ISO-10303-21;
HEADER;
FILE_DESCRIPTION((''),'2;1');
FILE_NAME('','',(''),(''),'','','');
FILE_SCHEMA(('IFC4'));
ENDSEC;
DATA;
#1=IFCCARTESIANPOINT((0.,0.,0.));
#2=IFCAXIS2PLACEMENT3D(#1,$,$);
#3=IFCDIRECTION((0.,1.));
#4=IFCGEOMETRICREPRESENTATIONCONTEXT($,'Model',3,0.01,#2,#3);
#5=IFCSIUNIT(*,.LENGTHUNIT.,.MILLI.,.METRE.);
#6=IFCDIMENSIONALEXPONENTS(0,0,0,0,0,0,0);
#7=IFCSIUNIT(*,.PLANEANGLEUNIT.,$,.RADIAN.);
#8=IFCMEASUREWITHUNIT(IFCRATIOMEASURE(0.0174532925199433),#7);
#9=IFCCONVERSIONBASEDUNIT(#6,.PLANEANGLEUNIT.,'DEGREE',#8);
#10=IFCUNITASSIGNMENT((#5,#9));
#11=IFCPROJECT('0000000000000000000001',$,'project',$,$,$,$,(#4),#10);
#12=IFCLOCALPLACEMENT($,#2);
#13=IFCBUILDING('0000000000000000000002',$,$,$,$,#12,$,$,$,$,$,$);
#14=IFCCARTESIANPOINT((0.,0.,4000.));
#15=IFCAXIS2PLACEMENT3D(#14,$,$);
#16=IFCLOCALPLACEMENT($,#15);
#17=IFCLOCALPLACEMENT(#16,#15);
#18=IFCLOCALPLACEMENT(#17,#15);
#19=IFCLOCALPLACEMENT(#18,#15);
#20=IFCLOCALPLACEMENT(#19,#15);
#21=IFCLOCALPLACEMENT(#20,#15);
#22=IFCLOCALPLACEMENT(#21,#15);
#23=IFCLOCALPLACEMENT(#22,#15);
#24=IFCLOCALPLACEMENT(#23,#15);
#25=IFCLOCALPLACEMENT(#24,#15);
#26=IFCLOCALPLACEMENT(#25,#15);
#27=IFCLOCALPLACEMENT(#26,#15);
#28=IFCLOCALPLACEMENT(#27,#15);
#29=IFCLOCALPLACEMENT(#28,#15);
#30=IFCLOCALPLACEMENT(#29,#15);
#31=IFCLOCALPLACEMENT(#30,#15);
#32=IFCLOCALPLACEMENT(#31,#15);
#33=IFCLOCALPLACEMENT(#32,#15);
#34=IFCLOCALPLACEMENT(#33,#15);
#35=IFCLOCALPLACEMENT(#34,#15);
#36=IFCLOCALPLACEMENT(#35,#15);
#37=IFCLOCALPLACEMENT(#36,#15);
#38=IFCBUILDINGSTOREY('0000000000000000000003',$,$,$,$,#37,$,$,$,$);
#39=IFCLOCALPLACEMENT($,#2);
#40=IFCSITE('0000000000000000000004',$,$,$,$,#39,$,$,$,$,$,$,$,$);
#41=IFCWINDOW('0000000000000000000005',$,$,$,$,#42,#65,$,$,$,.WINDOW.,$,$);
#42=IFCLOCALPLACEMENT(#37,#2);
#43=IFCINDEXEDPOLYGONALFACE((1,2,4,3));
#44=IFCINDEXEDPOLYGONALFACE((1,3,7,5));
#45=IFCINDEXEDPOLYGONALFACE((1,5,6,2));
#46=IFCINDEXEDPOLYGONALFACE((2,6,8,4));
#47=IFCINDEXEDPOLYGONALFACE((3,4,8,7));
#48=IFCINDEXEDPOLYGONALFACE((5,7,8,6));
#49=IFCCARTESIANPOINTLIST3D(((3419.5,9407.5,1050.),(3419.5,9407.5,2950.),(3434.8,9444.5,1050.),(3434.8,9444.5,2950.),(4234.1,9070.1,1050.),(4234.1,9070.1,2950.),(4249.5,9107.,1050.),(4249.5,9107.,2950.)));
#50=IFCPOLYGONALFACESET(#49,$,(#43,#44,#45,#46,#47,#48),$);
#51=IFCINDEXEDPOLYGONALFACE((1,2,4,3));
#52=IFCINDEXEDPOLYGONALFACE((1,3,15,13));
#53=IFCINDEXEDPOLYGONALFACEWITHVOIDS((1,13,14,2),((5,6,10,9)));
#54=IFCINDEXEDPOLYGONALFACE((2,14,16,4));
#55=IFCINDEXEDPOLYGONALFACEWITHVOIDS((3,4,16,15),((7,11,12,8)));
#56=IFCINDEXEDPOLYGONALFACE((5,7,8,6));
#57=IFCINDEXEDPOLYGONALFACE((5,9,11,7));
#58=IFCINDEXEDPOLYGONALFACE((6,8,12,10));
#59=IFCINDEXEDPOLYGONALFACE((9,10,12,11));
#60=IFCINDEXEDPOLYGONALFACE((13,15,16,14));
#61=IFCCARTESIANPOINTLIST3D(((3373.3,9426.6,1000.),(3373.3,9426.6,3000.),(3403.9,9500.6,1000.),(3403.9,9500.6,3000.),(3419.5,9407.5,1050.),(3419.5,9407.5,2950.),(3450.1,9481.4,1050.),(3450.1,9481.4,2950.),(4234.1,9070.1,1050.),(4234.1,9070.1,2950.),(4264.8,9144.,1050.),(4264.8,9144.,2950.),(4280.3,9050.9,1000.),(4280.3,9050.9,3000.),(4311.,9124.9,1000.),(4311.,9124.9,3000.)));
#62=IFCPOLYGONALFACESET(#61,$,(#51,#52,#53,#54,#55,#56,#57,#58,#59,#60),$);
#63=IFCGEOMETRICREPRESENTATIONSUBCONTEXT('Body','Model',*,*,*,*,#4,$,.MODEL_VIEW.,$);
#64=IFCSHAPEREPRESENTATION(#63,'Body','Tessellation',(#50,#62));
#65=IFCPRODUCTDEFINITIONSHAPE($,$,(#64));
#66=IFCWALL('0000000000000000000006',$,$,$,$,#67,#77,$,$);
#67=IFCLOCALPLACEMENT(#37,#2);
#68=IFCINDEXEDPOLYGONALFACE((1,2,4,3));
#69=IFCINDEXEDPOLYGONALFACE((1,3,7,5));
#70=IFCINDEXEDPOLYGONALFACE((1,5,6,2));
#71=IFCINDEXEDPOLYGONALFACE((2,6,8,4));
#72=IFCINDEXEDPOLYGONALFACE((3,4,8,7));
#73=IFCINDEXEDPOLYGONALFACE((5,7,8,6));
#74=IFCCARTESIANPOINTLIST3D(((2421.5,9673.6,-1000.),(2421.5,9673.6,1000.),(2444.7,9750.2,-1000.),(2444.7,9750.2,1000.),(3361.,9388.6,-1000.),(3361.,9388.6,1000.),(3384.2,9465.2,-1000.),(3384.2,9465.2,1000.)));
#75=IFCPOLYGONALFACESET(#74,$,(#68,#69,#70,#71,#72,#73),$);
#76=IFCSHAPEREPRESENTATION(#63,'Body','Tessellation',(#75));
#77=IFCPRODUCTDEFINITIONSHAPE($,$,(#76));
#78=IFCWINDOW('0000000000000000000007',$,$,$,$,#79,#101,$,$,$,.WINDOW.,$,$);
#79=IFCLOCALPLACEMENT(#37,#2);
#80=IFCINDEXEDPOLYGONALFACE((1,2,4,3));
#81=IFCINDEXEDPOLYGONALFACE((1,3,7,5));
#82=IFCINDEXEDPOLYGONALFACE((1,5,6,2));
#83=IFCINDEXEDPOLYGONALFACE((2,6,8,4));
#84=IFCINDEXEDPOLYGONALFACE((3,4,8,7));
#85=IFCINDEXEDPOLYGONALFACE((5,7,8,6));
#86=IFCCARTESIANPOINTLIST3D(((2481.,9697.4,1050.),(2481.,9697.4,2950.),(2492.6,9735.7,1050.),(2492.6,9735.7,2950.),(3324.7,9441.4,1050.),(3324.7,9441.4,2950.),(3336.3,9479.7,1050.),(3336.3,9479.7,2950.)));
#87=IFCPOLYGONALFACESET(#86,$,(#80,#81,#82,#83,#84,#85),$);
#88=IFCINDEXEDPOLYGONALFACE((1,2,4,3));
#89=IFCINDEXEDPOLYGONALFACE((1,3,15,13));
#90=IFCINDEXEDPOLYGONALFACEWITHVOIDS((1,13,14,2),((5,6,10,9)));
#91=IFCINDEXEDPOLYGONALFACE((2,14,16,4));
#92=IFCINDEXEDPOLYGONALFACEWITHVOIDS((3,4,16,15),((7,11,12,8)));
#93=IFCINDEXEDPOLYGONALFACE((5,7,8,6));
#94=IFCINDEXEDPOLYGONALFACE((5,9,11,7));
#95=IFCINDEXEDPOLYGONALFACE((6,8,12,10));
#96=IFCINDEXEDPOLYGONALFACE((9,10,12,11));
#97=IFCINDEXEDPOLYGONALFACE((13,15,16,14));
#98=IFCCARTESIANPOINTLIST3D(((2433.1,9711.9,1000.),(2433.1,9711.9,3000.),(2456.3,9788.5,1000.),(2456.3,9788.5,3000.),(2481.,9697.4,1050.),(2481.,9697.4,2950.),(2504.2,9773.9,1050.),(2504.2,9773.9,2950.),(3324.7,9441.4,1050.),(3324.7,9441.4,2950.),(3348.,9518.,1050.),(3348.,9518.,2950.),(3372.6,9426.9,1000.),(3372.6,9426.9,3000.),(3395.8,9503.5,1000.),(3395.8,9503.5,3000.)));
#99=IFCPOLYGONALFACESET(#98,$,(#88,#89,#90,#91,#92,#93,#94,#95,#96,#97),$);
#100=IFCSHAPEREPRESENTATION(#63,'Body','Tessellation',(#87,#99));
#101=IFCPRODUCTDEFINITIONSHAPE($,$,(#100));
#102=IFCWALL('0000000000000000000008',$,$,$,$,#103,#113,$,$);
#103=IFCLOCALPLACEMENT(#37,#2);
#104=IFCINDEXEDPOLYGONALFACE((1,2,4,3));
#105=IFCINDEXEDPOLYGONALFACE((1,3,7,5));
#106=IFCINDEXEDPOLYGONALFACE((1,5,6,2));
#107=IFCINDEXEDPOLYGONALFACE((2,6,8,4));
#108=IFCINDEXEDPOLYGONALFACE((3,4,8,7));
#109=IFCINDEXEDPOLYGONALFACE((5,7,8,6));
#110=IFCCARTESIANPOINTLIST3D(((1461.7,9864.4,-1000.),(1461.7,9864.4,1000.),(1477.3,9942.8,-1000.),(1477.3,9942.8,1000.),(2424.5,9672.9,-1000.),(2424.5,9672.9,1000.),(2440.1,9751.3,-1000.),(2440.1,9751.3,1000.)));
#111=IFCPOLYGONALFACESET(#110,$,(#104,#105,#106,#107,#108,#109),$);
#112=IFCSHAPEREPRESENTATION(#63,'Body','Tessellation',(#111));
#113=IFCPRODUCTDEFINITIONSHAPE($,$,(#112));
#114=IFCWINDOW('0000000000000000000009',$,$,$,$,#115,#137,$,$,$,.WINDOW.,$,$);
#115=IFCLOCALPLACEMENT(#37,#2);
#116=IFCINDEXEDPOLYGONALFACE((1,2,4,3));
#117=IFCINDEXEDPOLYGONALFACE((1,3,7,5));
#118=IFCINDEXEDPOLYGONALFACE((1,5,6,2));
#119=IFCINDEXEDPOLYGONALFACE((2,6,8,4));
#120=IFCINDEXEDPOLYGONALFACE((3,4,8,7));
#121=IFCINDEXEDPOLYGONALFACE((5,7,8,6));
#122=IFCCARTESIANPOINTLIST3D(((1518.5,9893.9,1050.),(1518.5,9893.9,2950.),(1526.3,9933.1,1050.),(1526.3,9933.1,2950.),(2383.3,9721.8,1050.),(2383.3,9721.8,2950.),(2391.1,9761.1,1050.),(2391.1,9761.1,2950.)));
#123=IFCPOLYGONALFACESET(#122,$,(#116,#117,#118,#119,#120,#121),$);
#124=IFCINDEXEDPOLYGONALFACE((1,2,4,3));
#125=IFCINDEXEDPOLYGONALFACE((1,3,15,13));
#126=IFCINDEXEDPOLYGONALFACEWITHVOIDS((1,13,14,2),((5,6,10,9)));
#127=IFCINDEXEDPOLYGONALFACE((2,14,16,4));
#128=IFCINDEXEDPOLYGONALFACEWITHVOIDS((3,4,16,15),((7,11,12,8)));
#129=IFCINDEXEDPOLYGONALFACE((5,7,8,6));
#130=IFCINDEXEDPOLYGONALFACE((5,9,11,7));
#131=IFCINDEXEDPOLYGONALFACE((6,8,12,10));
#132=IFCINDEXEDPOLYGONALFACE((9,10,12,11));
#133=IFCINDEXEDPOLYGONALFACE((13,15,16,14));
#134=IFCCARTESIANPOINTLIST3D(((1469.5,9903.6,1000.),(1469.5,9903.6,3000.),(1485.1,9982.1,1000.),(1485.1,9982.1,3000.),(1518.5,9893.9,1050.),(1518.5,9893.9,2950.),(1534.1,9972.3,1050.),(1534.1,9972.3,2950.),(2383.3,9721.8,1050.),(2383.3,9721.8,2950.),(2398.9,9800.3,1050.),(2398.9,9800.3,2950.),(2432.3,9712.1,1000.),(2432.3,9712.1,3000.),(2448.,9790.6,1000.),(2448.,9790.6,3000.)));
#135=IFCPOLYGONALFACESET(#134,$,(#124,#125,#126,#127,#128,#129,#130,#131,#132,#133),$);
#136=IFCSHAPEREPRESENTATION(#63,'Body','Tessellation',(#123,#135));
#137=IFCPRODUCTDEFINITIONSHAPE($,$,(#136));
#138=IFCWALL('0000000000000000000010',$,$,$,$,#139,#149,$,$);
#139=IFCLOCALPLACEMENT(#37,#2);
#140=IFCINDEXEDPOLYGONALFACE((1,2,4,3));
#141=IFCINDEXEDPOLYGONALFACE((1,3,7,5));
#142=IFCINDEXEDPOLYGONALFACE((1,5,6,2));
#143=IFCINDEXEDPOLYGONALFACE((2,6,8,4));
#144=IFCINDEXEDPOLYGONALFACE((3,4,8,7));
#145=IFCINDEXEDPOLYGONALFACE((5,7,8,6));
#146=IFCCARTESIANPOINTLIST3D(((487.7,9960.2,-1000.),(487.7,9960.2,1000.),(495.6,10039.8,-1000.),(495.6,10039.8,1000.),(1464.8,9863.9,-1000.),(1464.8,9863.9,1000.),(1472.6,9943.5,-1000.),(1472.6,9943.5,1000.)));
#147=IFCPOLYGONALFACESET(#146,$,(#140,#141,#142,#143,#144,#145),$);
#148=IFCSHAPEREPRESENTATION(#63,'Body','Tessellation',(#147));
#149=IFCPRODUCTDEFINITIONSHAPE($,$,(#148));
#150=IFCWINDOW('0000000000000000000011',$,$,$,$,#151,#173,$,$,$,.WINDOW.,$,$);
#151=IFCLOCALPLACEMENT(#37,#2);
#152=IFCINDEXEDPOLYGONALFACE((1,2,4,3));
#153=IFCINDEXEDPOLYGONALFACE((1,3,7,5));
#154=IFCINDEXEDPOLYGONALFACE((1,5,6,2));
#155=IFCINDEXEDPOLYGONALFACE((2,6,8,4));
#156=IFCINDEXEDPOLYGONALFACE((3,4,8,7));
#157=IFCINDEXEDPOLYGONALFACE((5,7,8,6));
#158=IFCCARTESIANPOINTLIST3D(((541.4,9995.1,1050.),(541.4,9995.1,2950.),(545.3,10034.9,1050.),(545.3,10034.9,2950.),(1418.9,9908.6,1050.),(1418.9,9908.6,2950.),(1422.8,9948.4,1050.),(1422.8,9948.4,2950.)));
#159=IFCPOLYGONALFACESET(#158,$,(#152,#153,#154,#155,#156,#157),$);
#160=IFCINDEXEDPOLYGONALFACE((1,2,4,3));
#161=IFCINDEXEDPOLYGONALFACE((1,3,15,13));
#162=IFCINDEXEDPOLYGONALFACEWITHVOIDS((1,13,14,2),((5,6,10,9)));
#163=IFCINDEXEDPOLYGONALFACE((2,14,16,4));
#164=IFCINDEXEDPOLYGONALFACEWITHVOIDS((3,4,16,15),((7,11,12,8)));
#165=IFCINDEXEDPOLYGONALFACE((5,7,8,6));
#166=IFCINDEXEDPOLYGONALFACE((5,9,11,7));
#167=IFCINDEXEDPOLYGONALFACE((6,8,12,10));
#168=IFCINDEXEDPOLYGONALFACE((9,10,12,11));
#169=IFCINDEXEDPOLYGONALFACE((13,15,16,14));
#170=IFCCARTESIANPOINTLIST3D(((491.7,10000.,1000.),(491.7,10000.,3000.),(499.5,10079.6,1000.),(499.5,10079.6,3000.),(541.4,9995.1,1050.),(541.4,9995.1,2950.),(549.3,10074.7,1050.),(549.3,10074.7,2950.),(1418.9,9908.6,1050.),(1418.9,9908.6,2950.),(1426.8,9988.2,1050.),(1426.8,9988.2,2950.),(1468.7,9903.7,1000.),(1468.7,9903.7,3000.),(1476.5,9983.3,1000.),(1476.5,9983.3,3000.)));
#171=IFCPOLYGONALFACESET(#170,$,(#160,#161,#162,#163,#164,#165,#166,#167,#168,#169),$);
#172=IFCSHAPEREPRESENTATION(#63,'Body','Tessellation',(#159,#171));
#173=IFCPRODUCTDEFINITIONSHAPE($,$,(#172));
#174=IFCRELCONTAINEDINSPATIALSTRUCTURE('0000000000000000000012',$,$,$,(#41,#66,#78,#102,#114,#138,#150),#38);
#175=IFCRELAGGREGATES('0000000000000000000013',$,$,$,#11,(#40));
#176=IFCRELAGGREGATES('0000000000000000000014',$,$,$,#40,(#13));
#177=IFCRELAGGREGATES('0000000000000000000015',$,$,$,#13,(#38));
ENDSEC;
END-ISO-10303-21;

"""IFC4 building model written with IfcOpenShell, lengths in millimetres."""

from ifc_helpers import new_model, entity, si_unit, converted_unit, direction, frame, origin, origin_2d, place, context, subcontext, project, spatial, rectangle, extrude, element, save


model = new_model("IFC4")

# Units and contexts
model_context = context("Model", 3, precision=0.01, world=origin(), true_north=direction((0.0, 1.0)))
body_context = subcontext(model_context, "Body", "Model", "MODEL_VIEW")
ifc_project = project(units=[si_unit("LENGTHUNIT", "METRE", prefix="MILLI"), converted_unit("PLANEANGLEUNIT", "DEGREE", entity("IfcRatioMeasure", 0.0174532925199433), si_unit("PLANEANGLEUNIT", "RADIAN"), dimensions=[0, 0, 0, 0, 0, 0, 0])], contexts=[model_context])

# Site, building, storey
site_placement = place(None, origin())
site = spatial("IfcSite", under=ifc_project, at=site_placement)
building_placement = place(None, origin())
building = spatial("IfcBuilding", under=site, at=building_placement)
placement_1 = place(None, frame((0.0, 0.0, 4000.0)))
placement_2 = place(placement_1, frame((0.0, 0.0, 4000.0)))
placement_3 = place(placement_2, frame((0.0, 0.0, 4000.0)))
placement_4 = place(placement_3, frame((0.0, 0.0, 4000.0)))
placement_5 = place(placement_4, frame((0.0, 0.0, 4000.0)))
placement_6 = place(placement_5, frame((0.0, 0.0, 4000.0)))
placement_7 = place(placement_6, frame((0.0, 0.0, 4000.0)))
placement_8 = place(placement_7, frame((0.0, 0.0, 4000.0)))
placement_9 = place(placement_8, frame((0.0, 0.0, 4000.0)))
placement_10 = place(placement_9, frame((0.0, 0.0, 4000.0)))
placement_11 = place(placement_10, frame((0.0, 0.0, 4000.0)))
placement_12 = place(placement_11, frame((0.0, 0.0, 4000.0)))
placement_13 = place(placement_12, frame((0.0, 0.0, 4000.0)))
placement_14 = place(placement_13, frame((0.0, 0.0, 4000.0)))
placement_15 = place(placement_14, frame((0.0, 0.0, 4000.0)))
placement_16 = place(placement_15, frame((0.0, 0.0, 4000.0)))
placement_17 = place(placement_16, frame((0.0, 0.0, 4000.0)))
placement_18 = place(placement_17, frame((0.0, 0.0, 4000.0)))
placement_19 = place(placement_18, frame((0.0, 0.0, 4000.0)))
placement_20 = place(placement_19, frame((0.0, 0.0, 4000.0)))
placement_21 = place(placement_20, frame((0.0, 0.0, 4000.0)))
storey_placement = place(placement_21, frame((0.0, 0.0, 4000.0)))
storey = spatial("IfcBuildingStorey", under=building, at=storey_placement)

# Shared definitions
cartesian_point_1 = entity("IfcCartesianPoint", [-440.9, -950.0])
shared_polyline = entity("IfcPolyline", [cartesian_point_1, entity("IfcCartesianPoint", [-440.9, 950.0]), entity("IfcCartesianPoint", [-440.9, 950.0]), entity("IfcCartesianPoint", [440.9, 950.0]), entity("IfcCartesianPoint", [440.9, 950.0]), entity("IfcCartesianPoint", [440.9, -950.0]), entity("IfcCartesianPoint", [440.9, -950.0]), entity("IfcCartesianPoint", [-440.9, -950.0]), cartesian_point_1])

# Window
window_1_placement = place(storey_placement, frame((3826.8, 9238.8, 2000.0), z_axis=(0.0, 0.0, 1.0), x_axis=(-9238.795337, 3826.834296, 0.0)))
cartesian_point_2 = entity("IfcCartesianPoint", [-490.9, -1000.0])
element("IfcWindow", 1, at=window_1_placement, inside=storey, PredefinedType="WINDOW", context=body_context, shape_type="SweptSolid", body=[
    entity("IfcExtrudedAreaSolid", entity("IfcArbitraryClosedProfileDef", "AREA", None, shared_polyline), entity("IfcAxis2Placement3D", entity("IfcCartesianPoint", [0.0, 0.0, 0.0]), entity("IfcDirection", [0.0, -1.0, 0.0]), entity("IfcDirection", [1.0, 0.0, 0.0])), entity("IfcDirection", [0.0, 0.0, 1.0]), 40.0),
    entity("IfcExtrudedAreaSolid", entity("IfcArbitraryProfileDefWithVoids", "AREA", None, entity("IfcPolyline", [cartesian_point_2, entity("IfcCartesianPoint", [-490.9, 1000.0]), entity("IfcCartesianPoint", [-490.9, 1000.0]), entity("IfcCartesianPoint", [490.9, 1000.0]), entity("IfcCartesianPoint", [490.9, 1000.0]), entity("IfcCartesianPoint", [490.9, -1000.0]), entity("IfcCartesianPoint", [490.9, -1000.0]), entity("IfcCartesianPoint", [-490.9, -1000.0]), cartesian_point_2]), [shared_polyline]), entity("IfcAxis2Placement3D", entity("IfcCartesianPoint", [0.0, 0.0, 0.0]), entity("IfcDirection", [0.0, -1.0, 0.0]), entity("IfcDirection", [1.0, 0.0, 0.0])), entity("IfcDirection", [0.0, 0.0, 1.0]), 80.0),
])

# Wall
wall_1_placement = place(storey_placement, frame((2902.8, 9569.4, -1000.0), z_axis=(0.0, 0.0, 1.0), x_axis=(-9569.403482, 2902.846361, 0.0)))
element("IfcWall", 2, at=wall_1_placement, inside=storey, context=body_context, shape_type="SweptSolid", body=[
    extrude(rectangle(XDim=981.7, YDim=80.0, at=origin_2d()), origin(), (0.0, 0.0, 1.0), 2000.0),
])

# Window
window_2_placement = place(storey_placement, frame((2902.8, 9569.4, 2000.0), z_axis=(0.0, 0.0, 1.0), x_axis=(-9569.403482, 2902.846361, 0.0)))
cartesian_point_3 = entity("IfcCartesianPoint", [-490.9, -1000.0])
element("IfcWindow", 3, at=window_2_placement, inside=storey, PredefinedType="WINDOW", context=body_context, shape_type="SweptSolid", body=[
    entity("IfcExtrudedAreaSolid", entity("IfcArbitraryClosedProfileDef", "AREA", None, shared_polyline), entity("IfcAxis2Placement3D", entity("IfcCartesianPoint", [0.0, 0.0, 0.0]), entity("IfcDirection", [0.0, -1.0, 0.0]), entity("IfcDirection", [1.0, 0.0, 0.0])), entity("IfcDirection", [0.0, 0.0, 1.0]), 40.0),
    entity("IfcExtrudedAreaSolid", entity("IfcArbitraryProfileDefWithVoids", "AREA", None, entity("IfcPolyline", [cartesian_point_3, entity("IfcCartesianPoint", [-490.9, 1000.0]), entity("IfcCartesianPoint", [-490.9, 1000.0]), entity("IfcCartesianPoint", [490.9, 1000.0]), entity("IfcCartesianPoint", [490.9, 1000.0]), entity("IfcCartesianPoint", [490.9, -1000.0]), entity("IfcCartesianPoint", [490.9, -1000.0]), entity("IfcCartesianPoint", [-490.9, -1000.0]), cartesian_point_3]), [shared_polyline]), entity("IfcAxis2Placement3D", entity("IfcCartesianPoint", [0.0, 0.0, 0.0]), entity("IfcDirection", [0.0, -1.0, 0.0]), entity("IfcDirection", [1.0, 0.0, 0.0])), entity("IfcDirection", [0.0, 0.0, 1.0]), 80.0),
])

# Wall
wall_2_placement = place(storey_placement, frame((1950.9, 9807.9, -1000.0), z_axis=(0.0, 0.0, 1.0), x_axis=(-9807.852733, 1950.903576, 0.0)))
element("IfcWall", 4, at=wall_2_placement, inside=storey, context=body_context, shape_type="SweptSolid", body=[
    extrude(rectangle(XDim=981.7, YDim=80.0, at=origin_2d()), origin(), (0.0, 0.0, 1.0), 2000.0),
])

# Window
window_3_placement = place(storey_placement, frame((1950.9, 9807.9, 2000.0), z_axis=(0.0, 0.0, 1.0), x_axis=(-9807.852733, 1950.903576, 0.0)))
cartesian_point_4 = entity("IfcCartesianPoint", [-490.9, -1000.0])
element("IfcWindow", 5, at=window_3_placement, inside=storey, PredefinedType="WINDOW", context=body_context, shape_type="SweptSolid", body=[
    entity("IfcExtrudedAreaSolid", entity("IfcArbitraryClosedProfileDef", "AREA", None, shared_polyline), entity("IfcAxis2Placement3D", entity("IfcCartesianPoint", [0.0, 0.0, 0.0]), entity("IfcDirection", [0.0, -1.0, 0.0]), entity("IfcDirection", [1.0, 0.0, 0.0])), entity("IfcDirection", [0.0, 0.0, 1.0]), 40.0),
    entity("IfcExtrudedAreaSolid", entity("IfcArbitraryProfileDefWithVoids", "AREA", None, entity("IfcPolyline", [cartesian_point_4, entity("IfcCartesianPoint", [-490.9, 1000.0]), entity("IfcCartesianPoint", [-490.9, 1000.0]), entity("IfcCartesianPoint", [490.9, 1000.0]), entity("IfcCartesianPoint", [490.9, 1000.0]), entity("IfcCartesianPoint", [490.9, -1000.0]), entity("IfcCartesianPoint", [490.9, -1000.0]), entity("IfcCartesianPoint", [-490.9, -1000.0]), cartesian_point_4]), [shared_polyline]), entity("IfcAxis2Placement3D", entity("IfcCartesianPoint", [0.0, 0.0, 0.0]), entity("IfcDirection", [0.0, -1.0, 0.0]), entity("IfcDirection", [1.0, 0.0, 0.0])), entity("IfcDirection", [0.0, 0.0, 1.0]), 80.0),
])

# Wall
wall_3_placement = place(storey_placement, frame((980.2, 9951.8, -1000.0), z_axis=(0.0, 0.0, 1.0), x_axis=(-9951.84727, 980.171366, 0.0)))
element("IfcWall", 6, at=wall_3_placement, inside=storey, context=body_context, shape_type="SweptSolid", body=[
    extrude(rectangle(XDim=981.7, YDim=80.0, at=origin_2d()), origin(), (0.0, 0.0, 1.0), 2000.0),
])

# Window
window_4_placement = place(storey_placement, frame((980.2, 9951.8, 2000.0), z_axis=(0.0, 0.0, 1.0), x_axis=(-9951.84727, 980.171366, 0.0)))
cartesian_point_5 = entity("IfcCartesianPoint", [-490.9, -1000.0])
element("IfcWindow", 7, at=window_4_placement, inside=storey, PredefinedType="WINDOW", context=body_context, shape_type="SweptSolid", body=[
    entity("IfcExtrudedAreaSolid", entity("IfcArbitraryClosedProfileDef", "AREA", None, shared_polyline), entity("IfcAxis2Placement3D", entity("IfcCartesianPoint", [0.0, 0.0, 0.0]), entity("IfcDirection", [0.0, -1.0, 0.0]), entity("IfcDirection", [1.0, 0.0, 0.0])), entity("IfcDirection", [0.0, 0.0, 1.0]), 40.0),
    entity("IfcExtrudedAreaSolid", entity("IfcArbitraryProfileDefWithVoids", "AREA", None, entity("IfcPolyline", [cartesian_point_5, entity("IfcCartesianPoint", [-490.9, 1000.0]), entity("IfcCartesianPoint", [-490.9, 1000.0]), entity("IfcCartesianPoint", [490.9, 1000.0]), entity("IfcCartesianPoint", [490.9, 1000.0]), entity("IfcCartesianPoint", [490.9, -1000.0]), entity("IfcCartesianPoint", [490.9, -1000.0]), entity("IfcCartesianPoint", [-490.9, -1000.0]), cartesian_point_5]), [shared_polyline]), entity("IfcAxis2Placement3D", entity("IfcCartesianPoint", [0.0, 0.0, 0.0]), entity("IfcDirection", [0.0, -1.0, 0.0]), entity("IfcDirection", [1.0, 0.0, 0.0])), entity("IfcDirection", [0.0, 0.0, 1.0]), 80.0),
])

save(model, "model.ifc")
